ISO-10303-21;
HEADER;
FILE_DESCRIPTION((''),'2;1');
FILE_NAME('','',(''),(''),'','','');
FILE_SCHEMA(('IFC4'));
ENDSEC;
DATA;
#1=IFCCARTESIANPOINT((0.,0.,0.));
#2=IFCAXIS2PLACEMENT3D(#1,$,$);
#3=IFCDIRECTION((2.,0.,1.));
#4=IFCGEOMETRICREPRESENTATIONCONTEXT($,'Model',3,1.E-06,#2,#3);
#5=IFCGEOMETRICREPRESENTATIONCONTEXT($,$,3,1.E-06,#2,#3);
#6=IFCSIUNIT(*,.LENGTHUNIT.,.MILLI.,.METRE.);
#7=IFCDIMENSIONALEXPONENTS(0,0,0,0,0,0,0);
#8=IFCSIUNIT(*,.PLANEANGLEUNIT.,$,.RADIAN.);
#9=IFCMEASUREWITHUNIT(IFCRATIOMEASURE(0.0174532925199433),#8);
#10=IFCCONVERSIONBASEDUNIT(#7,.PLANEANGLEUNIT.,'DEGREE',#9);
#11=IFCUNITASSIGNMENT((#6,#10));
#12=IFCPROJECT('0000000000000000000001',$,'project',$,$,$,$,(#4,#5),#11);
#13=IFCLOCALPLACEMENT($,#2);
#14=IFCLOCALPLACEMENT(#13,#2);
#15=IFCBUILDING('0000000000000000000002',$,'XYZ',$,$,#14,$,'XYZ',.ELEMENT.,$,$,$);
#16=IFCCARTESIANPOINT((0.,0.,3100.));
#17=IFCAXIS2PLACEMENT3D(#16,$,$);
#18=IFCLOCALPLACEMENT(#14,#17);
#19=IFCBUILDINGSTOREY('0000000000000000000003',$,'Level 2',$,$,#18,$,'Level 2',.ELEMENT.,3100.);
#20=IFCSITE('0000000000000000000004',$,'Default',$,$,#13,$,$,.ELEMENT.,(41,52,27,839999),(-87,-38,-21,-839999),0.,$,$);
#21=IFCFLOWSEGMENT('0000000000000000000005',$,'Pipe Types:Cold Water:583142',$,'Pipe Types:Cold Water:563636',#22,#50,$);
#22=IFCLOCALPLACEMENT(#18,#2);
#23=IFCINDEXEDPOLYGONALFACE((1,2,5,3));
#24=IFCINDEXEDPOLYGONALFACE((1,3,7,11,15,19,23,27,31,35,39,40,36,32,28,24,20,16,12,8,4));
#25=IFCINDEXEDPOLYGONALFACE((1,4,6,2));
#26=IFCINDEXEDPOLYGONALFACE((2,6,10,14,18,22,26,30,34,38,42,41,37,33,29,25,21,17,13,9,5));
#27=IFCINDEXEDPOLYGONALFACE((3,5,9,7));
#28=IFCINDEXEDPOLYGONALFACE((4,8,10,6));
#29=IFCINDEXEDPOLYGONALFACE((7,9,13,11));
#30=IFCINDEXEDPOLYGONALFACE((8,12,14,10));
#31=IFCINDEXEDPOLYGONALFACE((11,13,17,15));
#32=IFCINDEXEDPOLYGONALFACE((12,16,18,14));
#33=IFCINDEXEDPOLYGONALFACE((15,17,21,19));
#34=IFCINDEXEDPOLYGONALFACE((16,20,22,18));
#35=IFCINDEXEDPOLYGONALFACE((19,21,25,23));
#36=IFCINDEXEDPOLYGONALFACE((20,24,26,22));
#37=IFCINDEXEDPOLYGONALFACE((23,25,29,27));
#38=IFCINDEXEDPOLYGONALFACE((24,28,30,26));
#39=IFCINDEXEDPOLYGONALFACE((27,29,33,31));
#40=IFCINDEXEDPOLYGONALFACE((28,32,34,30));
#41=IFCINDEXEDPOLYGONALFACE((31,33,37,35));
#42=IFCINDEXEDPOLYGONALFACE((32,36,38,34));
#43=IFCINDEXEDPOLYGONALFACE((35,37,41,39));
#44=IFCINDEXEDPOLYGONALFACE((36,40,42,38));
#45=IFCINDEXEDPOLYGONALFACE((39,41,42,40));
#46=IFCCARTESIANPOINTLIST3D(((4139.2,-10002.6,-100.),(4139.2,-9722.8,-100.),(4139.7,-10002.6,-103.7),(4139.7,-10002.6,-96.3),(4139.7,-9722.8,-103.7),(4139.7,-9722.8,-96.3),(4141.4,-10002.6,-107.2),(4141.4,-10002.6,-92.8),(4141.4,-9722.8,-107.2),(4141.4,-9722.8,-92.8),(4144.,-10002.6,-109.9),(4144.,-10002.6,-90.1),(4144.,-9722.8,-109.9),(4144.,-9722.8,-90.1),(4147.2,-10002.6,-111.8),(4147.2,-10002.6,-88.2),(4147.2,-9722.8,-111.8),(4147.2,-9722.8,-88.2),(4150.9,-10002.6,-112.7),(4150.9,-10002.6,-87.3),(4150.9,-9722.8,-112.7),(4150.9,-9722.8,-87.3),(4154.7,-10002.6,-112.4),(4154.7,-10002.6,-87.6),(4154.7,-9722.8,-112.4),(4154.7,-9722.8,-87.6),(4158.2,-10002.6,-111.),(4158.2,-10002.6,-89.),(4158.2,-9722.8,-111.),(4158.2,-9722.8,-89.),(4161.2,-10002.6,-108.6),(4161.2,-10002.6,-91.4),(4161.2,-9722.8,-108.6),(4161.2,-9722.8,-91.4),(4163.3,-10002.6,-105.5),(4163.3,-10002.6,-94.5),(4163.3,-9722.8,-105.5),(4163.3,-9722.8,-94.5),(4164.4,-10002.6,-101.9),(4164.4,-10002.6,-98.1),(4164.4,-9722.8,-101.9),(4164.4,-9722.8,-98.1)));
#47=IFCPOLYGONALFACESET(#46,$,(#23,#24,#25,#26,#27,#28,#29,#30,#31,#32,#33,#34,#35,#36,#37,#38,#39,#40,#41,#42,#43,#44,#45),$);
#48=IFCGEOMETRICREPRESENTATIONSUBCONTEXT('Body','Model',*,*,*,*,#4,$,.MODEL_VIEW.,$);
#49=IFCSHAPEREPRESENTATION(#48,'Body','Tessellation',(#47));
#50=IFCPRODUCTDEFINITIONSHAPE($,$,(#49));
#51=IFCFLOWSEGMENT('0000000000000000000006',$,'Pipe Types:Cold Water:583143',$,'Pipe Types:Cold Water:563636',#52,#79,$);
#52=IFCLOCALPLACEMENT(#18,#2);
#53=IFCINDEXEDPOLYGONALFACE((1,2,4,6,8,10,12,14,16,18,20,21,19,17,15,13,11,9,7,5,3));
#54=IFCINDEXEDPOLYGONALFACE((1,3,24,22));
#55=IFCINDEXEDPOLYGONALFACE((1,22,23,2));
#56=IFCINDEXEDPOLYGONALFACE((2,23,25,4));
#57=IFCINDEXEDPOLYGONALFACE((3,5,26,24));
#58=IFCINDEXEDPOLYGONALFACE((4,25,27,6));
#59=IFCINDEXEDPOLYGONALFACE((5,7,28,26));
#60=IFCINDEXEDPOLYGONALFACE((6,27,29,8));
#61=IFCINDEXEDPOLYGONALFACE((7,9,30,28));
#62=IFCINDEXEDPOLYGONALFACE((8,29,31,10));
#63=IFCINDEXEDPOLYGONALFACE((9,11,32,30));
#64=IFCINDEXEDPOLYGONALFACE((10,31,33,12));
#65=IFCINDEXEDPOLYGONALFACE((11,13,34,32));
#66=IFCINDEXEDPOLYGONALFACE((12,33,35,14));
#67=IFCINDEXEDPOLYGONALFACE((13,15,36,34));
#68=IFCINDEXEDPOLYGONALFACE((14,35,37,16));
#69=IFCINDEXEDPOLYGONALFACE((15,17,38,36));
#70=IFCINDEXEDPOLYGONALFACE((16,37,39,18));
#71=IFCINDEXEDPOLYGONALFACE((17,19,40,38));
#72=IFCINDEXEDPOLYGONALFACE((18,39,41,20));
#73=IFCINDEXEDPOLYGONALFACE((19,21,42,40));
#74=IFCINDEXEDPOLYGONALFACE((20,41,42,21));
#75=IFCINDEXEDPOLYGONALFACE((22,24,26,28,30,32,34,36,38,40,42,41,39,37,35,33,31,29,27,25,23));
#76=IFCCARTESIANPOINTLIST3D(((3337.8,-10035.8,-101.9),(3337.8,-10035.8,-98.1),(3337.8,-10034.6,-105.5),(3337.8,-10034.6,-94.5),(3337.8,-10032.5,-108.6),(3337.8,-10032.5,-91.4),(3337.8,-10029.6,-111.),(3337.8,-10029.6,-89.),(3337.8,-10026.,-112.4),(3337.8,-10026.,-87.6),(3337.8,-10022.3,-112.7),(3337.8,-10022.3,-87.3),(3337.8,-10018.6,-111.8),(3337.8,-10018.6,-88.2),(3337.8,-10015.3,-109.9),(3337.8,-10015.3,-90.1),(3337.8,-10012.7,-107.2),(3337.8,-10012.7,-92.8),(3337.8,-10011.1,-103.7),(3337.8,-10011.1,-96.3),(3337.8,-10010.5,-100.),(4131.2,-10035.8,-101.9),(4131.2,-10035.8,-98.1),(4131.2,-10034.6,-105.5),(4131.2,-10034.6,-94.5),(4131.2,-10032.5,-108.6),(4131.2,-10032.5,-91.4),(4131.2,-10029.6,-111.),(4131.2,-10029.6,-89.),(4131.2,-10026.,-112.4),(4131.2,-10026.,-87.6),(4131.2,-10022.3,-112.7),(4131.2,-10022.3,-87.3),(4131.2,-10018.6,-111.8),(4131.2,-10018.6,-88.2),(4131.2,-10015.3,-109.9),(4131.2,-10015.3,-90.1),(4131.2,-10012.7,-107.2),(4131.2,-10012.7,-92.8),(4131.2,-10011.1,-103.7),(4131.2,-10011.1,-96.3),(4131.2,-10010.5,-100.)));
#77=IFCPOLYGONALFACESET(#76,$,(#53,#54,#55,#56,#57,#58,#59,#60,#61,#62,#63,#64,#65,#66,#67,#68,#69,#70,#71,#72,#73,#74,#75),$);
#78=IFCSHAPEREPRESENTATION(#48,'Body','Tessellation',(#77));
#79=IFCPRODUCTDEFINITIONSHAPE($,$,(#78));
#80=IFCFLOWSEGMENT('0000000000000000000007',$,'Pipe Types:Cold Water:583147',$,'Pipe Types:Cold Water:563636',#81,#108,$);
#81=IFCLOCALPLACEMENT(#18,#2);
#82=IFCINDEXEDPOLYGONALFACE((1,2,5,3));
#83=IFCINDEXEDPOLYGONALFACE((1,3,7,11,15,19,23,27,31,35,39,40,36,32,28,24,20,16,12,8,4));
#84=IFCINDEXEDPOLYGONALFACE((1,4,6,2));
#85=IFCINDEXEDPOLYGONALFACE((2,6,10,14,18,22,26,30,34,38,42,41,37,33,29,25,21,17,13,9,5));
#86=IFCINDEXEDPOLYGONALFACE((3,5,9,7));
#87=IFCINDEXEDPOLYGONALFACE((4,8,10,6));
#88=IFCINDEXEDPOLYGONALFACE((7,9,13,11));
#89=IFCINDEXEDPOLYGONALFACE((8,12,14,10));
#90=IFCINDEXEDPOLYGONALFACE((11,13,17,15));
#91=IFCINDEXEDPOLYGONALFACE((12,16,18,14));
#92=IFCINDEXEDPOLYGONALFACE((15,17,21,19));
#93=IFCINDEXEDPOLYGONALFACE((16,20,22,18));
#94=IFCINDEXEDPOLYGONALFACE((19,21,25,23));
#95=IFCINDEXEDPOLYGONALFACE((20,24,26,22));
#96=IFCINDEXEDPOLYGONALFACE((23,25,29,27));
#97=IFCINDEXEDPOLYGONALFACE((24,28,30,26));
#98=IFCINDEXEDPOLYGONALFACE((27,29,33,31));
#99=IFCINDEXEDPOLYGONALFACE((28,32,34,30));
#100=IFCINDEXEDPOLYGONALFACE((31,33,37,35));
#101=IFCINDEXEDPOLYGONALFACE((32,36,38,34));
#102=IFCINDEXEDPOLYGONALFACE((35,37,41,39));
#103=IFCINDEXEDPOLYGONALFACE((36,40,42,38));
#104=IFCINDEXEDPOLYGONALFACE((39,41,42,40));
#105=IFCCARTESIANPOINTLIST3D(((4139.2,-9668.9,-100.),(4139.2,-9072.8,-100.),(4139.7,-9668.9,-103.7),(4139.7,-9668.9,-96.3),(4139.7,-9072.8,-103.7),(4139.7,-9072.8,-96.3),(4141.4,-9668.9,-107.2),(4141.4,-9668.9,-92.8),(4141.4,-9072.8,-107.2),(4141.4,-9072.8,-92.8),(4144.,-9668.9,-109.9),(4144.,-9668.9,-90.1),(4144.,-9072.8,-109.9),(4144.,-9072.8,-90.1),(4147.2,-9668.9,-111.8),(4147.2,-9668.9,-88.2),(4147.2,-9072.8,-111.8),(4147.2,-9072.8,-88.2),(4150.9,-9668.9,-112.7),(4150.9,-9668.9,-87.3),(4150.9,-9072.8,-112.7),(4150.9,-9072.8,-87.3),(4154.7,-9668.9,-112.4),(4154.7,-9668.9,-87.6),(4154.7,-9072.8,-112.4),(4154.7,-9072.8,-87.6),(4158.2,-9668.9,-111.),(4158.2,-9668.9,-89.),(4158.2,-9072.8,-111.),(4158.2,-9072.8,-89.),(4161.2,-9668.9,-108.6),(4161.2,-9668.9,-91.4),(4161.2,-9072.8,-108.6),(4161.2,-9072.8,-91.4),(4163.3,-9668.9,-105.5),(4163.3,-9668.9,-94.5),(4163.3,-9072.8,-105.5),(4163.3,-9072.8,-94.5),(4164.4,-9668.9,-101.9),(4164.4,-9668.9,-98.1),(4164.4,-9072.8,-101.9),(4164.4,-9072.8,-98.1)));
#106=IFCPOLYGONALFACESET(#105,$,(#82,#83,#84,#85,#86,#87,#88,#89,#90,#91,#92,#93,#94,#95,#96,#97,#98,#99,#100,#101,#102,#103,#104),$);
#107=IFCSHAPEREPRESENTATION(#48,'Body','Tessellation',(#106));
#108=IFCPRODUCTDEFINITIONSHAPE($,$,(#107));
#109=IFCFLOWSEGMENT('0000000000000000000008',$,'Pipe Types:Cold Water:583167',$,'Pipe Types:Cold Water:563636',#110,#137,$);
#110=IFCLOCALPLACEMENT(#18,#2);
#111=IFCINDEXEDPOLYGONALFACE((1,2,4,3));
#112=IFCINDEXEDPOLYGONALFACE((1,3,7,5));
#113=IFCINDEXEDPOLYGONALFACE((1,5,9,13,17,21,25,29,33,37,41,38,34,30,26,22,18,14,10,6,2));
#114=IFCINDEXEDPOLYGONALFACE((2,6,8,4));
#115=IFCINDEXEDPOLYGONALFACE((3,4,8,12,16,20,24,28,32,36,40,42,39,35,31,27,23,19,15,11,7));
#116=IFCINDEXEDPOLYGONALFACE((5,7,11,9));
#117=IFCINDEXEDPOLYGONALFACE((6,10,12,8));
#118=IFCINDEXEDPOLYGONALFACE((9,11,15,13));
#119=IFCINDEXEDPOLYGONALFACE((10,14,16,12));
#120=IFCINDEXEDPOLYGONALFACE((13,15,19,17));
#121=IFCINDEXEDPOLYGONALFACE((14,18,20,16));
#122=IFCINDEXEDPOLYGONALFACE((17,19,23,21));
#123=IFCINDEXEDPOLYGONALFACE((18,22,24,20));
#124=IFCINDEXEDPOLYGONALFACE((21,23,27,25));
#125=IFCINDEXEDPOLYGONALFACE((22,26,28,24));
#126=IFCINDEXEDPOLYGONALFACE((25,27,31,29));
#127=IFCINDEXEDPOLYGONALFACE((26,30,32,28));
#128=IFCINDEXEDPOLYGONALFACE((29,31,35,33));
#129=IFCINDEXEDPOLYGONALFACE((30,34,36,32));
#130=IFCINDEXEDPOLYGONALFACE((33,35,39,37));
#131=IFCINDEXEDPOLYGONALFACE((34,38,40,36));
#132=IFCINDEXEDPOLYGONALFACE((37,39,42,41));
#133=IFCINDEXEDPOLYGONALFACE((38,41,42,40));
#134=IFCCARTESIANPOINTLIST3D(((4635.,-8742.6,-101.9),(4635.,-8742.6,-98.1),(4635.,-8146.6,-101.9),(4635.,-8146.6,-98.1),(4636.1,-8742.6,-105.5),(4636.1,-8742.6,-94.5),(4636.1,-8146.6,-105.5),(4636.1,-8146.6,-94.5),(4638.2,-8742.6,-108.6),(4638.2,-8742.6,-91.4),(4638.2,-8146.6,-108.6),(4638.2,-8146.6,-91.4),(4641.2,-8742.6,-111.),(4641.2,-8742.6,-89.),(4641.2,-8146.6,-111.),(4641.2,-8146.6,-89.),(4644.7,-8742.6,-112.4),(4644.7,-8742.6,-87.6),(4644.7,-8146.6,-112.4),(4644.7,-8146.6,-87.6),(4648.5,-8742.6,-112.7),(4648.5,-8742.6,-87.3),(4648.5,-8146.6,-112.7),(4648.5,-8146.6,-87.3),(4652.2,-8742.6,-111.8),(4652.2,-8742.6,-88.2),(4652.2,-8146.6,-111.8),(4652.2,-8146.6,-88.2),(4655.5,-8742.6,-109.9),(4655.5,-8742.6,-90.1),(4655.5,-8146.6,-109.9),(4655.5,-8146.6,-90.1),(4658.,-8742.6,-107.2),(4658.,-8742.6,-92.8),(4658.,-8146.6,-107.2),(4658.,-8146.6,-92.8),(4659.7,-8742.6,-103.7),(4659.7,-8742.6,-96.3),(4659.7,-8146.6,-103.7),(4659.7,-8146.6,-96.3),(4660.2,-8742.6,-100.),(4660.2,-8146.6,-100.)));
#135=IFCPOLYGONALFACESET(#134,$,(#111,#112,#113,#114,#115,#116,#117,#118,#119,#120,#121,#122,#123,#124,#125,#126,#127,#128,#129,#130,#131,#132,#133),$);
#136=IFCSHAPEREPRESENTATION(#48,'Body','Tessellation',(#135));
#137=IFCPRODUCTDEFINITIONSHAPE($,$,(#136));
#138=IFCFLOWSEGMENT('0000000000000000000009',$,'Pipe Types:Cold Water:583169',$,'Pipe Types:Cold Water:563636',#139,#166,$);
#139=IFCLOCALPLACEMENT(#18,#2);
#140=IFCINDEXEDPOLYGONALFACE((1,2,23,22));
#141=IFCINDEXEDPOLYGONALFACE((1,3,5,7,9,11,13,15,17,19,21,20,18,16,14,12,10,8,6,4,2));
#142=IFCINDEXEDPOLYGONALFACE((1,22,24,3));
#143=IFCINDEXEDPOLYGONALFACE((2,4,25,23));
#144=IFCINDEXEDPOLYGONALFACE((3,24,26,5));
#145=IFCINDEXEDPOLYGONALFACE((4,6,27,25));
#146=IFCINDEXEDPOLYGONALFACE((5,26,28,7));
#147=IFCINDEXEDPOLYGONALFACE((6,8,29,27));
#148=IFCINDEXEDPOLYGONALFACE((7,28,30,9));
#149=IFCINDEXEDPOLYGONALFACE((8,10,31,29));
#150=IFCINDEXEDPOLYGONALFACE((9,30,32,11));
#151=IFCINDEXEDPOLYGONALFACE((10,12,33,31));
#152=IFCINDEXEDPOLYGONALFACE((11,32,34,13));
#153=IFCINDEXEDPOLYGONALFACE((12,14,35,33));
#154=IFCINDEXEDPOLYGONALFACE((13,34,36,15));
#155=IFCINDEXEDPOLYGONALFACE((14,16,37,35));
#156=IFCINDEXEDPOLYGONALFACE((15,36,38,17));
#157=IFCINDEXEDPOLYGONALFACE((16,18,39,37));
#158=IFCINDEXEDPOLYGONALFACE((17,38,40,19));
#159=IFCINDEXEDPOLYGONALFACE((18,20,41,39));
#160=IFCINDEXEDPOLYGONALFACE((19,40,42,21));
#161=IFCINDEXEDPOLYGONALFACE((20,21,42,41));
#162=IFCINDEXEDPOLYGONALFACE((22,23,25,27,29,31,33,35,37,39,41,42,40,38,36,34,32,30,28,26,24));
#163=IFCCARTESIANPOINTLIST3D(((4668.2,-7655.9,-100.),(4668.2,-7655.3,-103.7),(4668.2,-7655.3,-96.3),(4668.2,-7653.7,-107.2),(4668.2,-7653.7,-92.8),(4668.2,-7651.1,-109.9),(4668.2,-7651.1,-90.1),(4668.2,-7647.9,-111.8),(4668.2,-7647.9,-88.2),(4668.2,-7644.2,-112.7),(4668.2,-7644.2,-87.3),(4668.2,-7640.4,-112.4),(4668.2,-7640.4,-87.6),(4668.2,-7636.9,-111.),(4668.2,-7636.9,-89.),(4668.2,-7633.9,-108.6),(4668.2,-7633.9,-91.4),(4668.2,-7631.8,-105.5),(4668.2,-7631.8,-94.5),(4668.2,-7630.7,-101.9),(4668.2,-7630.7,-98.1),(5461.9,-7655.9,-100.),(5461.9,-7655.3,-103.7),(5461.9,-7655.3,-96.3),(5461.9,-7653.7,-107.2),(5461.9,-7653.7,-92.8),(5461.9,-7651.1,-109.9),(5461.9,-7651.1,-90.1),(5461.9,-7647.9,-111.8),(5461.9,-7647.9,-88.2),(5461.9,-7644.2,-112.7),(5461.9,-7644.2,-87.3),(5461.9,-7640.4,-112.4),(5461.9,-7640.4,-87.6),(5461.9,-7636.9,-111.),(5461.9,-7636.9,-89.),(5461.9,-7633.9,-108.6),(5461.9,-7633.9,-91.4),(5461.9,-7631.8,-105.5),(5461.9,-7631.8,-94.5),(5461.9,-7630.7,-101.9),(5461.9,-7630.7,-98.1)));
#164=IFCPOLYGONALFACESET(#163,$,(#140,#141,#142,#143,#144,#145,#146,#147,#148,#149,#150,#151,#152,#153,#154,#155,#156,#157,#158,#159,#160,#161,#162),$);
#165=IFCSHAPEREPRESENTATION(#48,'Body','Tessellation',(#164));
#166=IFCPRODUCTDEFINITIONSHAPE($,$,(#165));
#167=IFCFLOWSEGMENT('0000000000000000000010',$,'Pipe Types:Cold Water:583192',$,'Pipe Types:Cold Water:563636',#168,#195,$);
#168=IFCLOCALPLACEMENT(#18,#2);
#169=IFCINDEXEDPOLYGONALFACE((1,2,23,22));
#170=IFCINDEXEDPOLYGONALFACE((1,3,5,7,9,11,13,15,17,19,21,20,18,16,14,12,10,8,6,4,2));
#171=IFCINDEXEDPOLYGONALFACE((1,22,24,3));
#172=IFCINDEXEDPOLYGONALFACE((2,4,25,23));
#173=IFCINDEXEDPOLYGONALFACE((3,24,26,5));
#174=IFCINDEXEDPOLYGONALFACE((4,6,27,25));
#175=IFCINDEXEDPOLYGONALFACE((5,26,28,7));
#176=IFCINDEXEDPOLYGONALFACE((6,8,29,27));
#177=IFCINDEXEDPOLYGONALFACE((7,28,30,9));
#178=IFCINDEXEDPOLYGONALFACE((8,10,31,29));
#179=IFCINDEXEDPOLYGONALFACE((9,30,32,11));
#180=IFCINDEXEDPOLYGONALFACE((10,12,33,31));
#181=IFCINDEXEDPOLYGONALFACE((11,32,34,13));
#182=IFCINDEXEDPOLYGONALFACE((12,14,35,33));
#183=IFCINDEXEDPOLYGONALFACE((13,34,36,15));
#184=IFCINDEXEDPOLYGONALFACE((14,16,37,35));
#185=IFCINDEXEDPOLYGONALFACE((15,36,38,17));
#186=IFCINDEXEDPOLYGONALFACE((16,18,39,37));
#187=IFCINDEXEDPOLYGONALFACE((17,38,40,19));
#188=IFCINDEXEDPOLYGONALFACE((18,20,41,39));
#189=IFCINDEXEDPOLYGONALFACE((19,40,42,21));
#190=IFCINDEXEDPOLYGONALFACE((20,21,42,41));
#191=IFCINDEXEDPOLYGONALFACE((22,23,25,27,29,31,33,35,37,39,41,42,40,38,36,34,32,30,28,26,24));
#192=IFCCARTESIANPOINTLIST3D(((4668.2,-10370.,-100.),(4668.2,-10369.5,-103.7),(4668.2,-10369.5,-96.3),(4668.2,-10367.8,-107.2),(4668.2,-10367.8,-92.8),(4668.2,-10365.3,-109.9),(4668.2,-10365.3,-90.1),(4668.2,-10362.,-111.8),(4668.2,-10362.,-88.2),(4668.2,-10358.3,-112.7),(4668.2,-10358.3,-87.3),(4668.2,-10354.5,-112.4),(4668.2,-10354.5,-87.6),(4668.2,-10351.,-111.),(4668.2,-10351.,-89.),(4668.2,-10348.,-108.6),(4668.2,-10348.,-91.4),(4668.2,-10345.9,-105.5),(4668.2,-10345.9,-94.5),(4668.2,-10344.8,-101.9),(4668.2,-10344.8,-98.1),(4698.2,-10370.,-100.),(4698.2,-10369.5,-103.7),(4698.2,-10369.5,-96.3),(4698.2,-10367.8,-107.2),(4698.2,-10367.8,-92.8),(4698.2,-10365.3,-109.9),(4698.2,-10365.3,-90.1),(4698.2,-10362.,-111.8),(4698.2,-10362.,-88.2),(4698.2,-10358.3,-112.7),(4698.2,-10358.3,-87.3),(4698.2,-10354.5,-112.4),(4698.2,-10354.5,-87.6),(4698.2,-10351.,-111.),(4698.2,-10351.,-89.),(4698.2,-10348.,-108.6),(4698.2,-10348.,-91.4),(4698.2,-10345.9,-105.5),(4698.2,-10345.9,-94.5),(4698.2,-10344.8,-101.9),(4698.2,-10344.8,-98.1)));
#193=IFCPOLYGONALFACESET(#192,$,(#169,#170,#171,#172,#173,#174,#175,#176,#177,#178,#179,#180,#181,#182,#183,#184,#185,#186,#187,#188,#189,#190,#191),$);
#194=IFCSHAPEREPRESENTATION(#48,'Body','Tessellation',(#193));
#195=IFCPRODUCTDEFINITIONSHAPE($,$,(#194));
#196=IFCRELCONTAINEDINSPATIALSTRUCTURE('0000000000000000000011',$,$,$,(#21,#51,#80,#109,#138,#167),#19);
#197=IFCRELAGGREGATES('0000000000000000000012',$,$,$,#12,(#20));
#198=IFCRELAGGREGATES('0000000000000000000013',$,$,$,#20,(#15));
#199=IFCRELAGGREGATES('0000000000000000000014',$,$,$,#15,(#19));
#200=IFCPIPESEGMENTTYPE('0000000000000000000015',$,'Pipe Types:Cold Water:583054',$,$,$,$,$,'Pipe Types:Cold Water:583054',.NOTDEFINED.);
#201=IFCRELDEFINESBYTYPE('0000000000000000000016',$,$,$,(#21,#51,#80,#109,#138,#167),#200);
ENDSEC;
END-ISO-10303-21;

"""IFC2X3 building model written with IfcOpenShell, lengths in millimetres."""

from ifc_helpers import new_model, entity, si_unit, converted_unit, direction, frame, frame_2d, origin, origin_2d_with_axis, place, context, subcontext, project, spatial, circle, extrude, type_object, element, save


model = new_model("IFC2X3")

# Units and contexts
model_context = context("Model", 3, precision=1e-06, world=origin(), true_north=direction((2.0, 0.0, 1.0)))
context_of_model = context(None, 3, precision=1e-06, world=origin(), true_north=direction((2.0, 0.0, 1.0)))
body_context = subcontext(model_context, "Body", "Model", "MODEL_VIEW")
ifc_project = project(units=[si_unit("LENGTHUNIT", "METRE", prefix="MILLI"), converted_unit("PLANEANGLEUNIT", "DEGREE", entity("IfcRatioMeasure", 0.0174532925199433), si_unit("PLANEANGLEUNIT", "RADIAN"), dimensions=[0, 0, 0, 0, 0, 0, 0])], contexts=[model_context, context_of_model])

# Site, building, storey
site_placement = place(None, origin())
site = spatial("IfcSite", under=ifc_project, at=site_placement, Name="Default", CompositionType="ELEMENT", RefLatitude=(41, 52, 27, 839999), RefLongitude=(-87, -38, -21, -839999), RefElevation=0.0)
building_placement = place(site_placement, origin())
building = spatial("IfcBuilding", under=site, at=building_placement, Name="XYZ", LongName="XYZ", CompositionType="ELEMENT")
storey_placement = place(building_placement, frame((0.0, 0.0, 3100.0)))
storey = spatial("IfcBuildingStorey", under=building, at=storey_placement, Name="Level 2", LongName="Level 2", CompositionType="ELEMENT", Elevation=3100.0)

# Flow segments
pipe_segment_type_1 = type_object("IfcPipeSegmentType", Name="Pipe Types:Cold Water:583054", ElementType="Pipe Types:Cold Water:583054", PredefinedType="NOTDEFINED")
flow_segment_1_placement = place(storey_placement, origin())
element("IfcFlowSegment", 1, at=flow_segment_1_placement, inside=storey, type_object=pipe_segment_type_1, Name="Pipe Types:Cold Water:583142", ObjectType="Pipe Types:Cold Water:563636", context=body_context, shape_type="SweptSolid", body=[
    extrude(circle(Radius=12.7, at=frame_2d((0.0, 0.0), x_axis=(1.0, 0.0))), frame((4151.9, -10002.6, -100.0), z_axis=(0.0, 1.0, 0.0), x_axis=(-1.0, 0.0, 0.0)), (0.0, 0.0, 1.0), 279.7),
])
flow_segment_2_placement = place(storey_placement, origin())
element("IfcFlowSegment", 2, at=flow_segment_2_placement, inside=storey, type_object=pipe_segment_type_1, Name="Pipe Types:Cold Water:583143", ObjectType="Pipe Types:Cold Water:563636", context=body_context, shape_type="SweptSolid", body=[
    extrude(circle(Radius=12.7, at=frame_2d((0.0, 0.0), x_axis=(1.0, 0.0))), frame((3337.8, -10023.2, -100.0), z_axis=(1.0, 0.0, 0.0), x_axis=(0.0, 1.0, 0.0)), (0.0, 0.0, 1.0), 793.4),
])
flow_segment_3_placement = place(storey_placement, origin())
element("IfcFlowSegment", 3, at=flow_segment_3_placement, inside=storey, type_object=pipe_segment_type_1, Name="Pipe Types:Cold Water:583147", ObjectType="Pipe Types:Cold Water:563636", context=body_context, shape_type="SweptSolid", body=[
    extrude(circle(Radius=12.7, at=frame_2d((0.0, 0.0), x_axis=(1.0, 0.0))), frame((4151.9, -9668.9, -100.0), z_axis=(0.0, 1.0, 0.0), x_axis=(-1.0, 0.0, 0.0)), (0.0, 0.0, 1.0), 596.0),
])
flow_segment_4_placement = place(storey_placement, origin())
element("IfcFlowSegment", 4, at=flow_segment_4_placement, inside=storey, type_object=pipe_segment_type_1, Name="Pipe Types:Cold Water:583167", ObjectType="Pipe Types:Cold Water:563636", context=body_context, shape_type="SweptSolid", body=[
    extrude(circle(Radius=12.7, at=frame_2d((0.0, 0.0), x_axis=(1.0, 0.0))), frame((4647.5, -8742.6, -100.0), z_axis=(0.0, 1.0, 0.0), x_axis=(1.0, 0.0, 0.0)), (0.0, 0.0, 1.0), 596.0),
])
flow_segment_5_placement = place(storey_placement, origin())
element("IfcFlowSegment", 5, at=flow_segment_5_placement, inside=storey, type_object=pipe_segment_type_1, Name="Pipe Types:Cold Water:583169", ObjectType="Pipe Types:Cold Water:563636", context=body_context, shape_type="SweptSolid", body=[
    extrude(circle(Radius=12.7, at=origin_2d_with_axis()), frame((4668.2, -7643.2, -100.0), z_axis=(1.0, 0.0, 0.0), x_axis=(0.0, -1.0, 0.0)), (0.0, 0.0, 1.0), 793.7),
])
flow_segment_6_placement = place(storey_placement, origin())
element("IfcFlowSegment", 6, at=flow_segment_6_placement, inside=storey, type_object=pipe_segment_type_1, Name="Pipe Types:Cold Water:583192", ObjectType="Pipe Types:Cold Water:563636", context=body_context, shape_type="SweptSolid", body=[
    extrude(circle(Radius=12.7, at=origin_2d_with_axis()), frame((4668.2, -10357.3, -100.0), z_axis=(1.0, 0.0, 0.0), x_axis=(0.0, -1.0, 0.0)), (0.0, 0.0, 1.0), 30.1),
])

save(model, "model.ifc")
